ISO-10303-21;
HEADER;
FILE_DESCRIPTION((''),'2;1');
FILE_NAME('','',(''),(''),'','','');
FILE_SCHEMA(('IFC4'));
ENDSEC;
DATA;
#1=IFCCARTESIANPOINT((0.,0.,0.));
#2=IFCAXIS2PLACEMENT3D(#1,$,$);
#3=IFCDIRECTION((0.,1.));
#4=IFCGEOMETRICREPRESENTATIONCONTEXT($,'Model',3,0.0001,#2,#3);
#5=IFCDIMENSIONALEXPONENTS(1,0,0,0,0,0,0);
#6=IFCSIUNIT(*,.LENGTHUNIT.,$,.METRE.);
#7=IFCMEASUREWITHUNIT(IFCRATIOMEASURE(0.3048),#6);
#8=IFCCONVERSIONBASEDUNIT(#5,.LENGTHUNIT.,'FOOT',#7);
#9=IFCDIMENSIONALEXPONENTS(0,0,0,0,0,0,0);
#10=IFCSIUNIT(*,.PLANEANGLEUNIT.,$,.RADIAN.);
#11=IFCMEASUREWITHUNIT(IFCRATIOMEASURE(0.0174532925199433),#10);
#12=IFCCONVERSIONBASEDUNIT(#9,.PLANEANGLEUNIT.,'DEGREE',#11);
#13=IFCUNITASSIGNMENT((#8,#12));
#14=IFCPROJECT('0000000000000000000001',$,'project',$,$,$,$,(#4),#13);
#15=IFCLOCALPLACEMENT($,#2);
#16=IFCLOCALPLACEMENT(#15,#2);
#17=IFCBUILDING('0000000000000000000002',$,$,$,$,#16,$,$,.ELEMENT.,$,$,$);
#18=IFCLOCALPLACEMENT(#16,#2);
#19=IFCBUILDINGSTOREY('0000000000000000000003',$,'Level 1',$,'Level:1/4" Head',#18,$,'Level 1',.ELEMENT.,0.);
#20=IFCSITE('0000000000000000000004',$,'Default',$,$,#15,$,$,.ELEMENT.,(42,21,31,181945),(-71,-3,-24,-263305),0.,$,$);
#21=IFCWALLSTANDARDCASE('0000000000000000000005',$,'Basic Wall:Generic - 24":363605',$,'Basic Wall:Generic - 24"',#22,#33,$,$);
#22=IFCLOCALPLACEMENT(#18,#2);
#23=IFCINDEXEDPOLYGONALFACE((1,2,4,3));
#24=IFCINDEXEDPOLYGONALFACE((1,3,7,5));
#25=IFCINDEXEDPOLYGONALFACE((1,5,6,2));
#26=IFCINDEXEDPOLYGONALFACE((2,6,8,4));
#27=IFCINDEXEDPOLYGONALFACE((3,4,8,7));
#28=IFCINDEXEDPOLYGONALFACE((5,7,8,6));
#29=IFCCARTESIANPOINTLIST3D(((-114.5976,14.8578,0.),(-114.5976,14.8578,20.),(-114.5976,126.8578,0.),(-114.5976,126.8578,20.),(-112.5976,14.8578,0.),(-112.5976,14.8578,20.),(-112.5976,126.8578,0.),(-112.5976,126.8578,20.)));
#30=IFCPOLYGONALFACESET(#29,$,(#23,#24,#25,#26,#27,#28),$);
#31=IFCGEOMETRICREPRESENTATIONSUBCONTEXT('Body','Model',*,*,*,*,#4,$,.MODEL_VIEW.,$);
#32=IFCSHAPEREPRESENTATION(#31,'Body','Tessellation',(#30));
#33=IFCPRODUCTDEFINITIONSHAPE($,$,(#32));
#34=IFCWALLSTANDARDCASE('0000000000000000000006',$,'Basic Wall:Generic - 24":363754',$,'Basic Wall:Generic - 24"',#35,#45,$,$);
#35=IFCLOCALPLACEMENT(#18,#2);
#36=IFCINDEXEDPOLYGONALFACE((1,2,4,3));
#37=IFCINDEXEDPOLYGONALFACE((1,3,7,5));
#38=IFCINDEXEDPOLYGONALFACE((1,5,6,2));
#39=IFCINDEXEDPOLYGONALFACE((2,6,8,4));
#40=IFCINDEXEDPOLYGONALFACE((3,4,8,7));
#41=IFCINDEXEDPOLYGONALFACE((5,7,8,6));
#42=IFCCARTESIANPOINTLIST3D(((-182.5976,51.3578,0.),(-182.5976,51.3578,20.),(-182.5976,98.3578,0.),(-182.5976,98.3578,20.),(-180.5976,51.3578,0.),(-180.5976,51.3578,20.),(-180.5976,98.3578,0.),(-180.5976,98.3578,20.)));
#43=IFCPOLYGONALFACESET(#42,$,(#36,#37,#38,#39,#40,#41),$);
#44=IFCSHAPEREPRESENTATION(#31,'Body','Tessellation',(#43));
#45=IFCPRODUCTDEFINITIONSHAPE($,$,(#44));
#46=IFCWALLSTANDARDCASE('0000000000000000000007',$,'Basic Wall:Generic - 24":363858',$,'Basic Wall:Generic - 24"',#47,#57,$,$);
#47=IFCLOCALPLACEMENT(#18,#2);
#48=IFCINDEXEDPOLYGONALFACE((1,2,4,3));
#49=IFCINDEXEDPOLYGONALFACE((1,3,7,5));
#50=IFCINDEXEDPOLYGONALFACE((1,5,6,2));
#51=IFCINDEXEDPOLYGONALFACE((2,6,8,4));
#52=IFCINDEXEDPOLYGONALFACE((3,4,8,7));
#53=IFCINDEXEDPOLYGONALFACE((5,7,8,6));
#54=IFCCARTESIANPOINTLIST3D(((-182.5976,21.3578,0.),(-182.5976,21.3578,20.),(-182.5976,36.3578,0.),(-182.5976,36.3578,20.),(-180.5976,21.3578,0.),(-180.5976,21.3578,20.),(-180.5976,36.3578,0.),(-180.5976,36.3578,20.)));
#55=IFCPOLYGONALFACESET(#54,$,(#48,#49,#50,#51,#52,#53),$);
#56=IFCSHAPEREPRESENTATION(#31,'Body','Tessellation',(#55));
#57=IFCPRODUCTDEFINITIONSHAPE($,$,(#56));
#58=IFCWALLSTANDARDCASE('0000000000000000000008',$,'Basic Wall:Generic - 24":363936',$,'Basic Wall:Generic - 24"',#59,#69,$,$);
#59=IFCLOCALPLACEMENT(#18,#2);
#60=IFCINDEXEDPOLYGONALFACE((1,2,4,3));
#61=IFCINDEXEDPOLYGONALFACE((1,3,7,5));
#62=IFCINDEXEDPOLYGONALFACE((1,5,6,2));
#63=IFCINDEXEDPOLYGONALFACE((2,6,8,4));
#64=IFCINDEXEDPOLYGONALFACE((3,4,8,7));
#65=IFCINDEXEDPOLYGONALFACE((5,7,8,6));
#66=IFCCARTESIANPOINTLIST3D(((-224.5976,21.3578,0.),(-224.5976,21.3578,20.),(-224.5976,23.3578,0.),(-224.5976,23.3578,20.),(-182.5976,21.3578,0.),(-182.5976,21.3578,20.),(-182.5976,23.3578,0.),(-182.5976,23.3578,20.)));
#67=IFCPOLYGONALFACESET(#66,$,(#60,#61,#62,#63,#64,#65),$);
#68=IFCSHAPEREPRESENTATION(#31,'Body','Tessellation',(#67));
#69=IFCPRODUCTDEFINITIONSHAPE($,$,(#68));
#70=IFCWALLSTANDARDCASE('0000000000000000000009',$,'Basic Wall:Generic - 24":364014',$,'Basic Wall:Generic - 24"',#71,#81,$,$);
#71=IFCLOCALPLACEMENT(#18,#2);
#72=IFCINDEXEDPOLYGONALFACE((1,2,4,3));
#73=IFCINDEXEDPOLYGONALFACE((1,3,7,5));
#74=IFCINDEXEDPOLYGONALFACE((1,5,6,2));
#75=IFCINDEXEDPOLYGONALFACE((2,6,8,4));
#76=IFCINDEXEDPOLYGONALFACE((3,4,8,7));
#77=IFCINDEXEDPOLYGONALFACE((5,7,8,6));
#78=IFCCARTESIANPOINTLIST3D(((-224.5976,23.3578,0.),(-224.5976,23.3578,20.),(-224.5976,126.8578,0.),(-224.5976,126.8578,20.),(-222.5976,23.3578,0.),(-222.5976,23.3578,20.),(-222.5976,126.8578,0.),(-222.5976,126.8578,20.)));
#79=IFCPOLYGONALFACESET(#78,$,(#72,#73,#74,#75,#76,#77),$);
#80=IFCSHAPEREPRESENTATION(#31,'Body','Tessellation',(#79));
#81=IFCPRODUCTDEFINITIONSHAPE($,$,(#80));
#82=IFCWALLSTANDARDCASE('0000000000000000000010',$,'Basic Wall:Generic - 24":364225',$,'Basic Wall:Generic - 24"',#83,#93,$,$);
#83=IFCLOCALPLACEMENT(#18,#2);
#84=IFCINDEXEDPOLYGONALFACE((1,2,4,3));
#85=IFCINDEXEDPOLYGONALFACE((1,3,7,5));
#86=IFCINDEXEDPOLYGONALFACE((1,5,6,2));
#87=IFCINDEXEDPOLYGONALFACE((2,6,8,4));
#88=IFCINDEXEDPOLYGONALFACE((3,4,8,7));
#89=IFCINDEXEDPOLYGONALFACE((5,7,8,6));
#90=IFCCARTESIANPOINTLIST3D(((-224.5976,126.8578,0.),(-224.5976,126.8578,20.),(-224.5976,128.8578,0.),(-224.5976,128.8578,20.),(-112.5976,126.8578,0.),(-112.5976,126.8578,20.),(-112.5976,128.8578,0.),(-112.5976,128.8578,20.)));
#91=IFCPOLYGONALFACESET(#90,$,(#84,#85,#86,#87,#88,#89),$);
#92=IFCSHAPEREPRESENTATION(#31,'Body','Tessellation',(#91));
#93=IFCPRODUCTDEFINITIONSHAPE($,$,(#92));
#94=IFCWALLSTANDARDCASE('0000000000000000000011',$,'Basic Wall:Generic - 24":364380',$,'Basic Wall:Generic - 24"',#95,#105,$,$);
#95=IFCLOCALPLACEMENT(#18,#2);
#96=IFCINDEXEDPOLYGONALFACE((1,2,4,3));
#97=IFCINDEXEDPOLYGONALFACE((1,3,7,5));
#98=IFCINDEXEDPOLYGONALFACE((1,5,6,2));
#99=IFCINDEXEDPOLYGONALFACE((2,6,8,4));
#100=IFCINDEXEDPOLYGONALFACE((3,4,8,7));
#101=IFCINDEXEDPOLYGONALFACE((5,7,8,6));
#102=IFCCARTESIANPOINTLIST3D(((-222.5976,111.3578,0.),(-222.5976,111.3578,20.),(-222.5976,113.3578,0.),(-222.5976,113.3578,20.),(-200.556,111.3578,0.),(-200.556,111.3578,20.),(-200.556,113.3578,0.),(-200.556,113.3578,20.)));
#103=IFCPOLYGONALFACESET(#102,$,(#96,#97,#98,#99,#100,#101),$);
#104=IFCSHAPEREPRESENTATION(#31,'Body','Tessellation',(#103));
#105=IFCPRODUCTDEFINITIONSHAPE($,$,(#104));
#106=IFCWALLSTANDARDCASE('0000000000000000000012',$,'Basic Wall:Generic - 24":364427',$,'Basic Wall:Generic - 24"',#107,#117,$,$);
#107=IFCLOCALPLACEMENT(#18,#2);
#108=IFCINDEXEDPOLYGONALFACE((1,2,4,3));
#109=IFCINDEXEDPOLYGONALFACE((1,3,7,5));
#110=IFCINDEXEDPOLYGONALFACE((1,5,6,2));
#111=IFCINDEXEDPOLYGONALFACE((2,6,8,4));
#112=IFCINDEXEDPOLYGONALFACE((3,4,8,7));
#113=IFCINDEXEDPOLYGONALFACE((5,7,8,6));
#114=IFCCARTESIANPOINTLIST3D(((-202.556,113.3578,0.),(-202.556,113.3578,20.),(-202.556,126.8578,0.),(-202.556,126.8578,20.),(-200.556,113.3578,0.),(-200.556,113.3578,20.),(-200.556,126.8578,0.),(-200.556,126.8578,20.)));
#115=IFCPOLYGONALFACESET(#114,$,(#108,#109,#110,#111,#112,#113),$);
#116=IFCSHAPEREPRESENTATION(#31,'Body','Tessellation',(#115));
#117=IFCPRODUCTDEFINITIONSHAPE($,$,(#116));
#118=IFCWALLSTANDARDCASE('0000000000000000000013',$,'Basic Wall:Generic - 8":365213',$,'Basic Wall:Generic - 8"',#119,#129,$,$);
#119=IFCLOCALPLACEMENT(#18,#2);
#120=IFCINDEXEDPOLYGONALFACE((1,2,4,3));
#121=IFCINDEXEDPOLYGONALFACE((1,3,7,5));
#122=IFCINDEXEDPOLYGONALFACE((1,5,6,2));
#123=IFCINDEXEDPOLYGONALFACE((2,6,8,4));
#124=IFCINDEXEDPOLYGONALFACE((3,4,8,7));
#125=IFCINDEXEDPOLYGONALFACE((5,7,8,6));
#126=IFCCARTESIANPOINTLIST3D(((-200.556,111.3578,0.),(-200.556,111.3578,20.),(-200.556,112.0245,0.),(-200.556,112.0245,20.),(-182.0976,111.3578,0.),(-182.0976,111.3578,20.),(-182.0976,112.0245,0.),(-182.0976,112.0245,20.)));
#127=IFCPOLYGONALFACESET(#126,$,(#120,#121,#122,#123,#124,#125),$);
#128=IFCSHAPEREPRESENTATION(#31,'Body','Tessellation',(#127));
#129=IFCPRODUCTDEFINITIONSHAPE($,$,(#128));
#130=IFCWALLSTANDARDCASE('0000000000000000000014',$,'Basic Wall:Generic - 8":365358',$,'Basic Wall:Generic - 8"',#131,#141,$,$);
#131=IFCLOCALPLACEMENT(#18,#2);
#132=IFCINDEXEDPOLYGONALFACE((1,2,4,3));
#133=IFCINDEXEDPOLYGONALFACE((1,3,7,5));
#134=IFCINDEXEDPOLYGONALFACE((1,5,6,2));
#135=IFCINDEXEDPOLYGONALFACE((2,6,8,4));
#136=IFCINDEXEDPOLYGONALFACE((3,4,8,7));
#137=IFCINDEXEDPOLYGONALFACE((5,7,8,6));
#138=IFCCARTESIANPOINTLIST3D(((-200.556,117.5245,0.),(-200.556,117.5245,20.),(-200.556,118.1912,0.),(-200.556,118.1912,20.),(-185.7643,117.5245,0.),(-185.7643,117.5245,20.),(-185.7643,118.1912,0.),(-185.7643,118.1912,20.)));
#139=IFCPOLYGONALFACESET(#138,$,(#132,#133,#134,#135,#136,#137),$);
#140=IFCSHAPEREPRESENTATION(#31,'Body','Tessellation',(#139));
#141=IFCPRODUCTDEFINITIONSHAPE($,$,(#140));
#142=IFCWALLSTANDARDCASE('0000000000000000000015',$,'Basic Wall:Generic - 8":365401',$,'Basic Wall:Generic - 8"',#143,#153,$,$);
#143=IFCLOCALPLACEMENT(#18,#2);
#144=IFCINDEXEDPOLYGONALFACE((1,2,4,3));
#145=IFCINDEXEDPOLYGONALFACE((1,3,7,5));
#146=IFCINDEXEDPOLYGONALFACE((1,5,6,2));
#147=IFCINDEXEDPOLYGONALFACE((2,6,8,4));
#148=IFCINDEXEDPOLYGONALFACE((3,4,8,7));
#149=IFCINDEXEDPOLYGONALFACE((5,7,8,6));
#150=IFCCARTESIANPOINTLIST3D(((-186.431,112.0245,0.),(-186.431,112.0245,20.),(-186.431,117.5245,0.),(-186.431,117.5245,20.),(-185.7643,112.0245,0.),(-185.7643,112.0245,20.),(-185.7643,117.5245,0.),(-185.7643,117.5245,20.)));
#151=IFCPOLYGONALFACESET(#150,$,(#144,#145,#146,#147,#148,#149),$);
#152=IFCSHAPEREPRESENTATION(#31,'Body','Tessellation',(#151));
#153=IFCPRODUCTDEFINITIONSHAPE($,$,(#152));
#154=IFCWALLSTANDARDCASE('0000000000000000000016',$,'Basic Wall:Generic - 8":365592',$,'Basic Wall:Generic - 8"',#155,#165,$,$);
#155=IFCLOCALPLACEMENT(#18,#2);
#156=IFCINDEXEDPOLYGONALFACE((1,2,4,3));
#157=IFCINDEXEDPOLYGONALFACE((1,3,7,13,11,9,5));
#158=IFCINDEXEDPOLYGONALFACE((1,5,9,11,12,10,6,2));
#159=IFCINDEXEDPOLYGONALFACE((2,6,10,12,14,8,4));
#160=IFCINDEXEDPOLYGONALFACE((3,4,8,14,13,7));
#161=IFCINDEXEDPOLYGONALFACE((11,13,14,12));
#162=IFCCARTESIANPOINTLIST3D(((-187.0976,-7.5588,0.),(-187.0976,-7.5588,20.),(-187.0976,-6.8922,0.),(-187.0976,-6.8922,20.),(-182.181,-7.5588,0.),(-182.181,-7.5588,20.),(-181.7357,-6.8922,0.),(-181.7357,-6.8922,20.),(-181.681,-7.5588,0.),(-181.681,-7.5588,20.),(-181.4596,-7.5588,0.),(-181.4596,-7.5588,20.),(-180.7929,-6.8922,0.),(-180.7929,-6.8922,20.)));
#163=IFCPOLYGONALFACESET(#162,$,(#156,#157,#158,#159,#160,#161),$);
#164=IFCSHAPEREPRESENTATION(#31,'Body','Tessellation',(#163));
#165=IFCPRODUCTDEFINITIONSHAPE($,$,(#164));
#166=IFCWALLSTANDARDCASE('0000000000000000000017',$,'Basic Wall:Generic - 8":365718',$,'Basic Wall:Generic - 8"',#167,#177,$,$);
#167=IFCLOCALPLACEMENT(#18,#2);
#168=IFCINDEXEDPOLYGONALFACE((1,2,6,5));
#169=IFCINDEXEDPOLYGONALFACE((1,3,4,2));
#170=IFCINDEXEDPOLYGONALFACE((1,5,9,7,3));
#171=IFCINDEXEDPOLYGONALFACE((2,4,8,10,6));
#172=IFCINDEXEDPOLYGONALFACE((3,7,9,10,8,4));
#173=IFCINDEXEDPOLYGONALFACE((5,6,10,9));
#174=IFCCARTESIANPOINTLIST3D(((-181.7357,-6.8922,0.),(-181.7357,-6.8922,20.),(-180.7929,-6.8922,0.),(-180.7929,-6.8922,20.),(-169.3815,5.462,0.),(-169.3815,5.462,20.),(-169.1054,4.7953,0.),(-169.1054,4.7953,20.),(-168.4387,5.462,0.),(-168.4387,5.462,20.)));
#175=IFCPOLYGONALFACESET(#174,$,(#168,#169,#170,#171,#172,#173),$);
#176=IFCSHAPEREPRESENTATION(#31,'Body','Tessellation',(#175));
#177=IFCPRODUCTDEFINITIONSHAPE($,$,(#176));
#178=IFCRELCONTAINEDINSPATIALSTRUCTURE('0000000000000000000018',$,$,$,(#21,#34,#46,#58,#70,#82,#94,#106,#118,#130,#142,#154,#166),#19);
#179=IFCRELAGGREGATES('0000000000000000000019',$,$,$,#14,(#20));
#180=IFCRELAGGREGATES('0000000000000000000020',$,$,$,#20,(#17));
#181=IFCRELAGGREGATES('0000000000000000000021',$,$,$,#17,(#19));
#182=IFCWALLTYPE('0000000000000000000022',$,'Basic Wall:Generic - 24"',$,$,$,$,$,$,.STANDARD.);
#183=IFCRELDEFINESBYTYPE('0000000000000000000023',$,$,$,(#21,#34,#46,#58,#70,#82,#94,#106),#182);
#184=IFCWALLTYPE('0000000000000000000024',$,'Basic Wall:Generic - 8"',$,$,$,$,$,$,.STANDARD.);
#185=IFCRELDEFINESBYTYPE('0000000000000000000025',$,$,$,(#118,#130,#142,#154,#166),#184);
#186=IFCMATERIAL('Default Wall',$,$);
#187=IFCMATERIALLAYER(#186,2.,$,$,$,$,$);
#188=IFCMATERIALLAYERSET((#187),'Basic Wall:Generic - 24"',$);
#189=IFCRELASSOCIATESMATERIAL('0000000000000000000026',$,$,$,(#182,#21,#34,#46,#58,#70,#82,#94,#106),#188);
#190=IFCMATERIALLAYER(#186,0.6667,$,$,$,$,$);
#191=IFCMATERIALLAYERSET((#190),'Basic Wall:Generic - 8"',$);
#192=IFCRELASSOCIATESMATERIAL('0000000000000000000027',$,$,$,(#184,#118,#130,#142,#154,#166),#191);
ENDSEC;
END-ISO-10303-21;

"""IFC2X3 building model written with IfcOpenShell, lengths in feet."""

from ifc_helpers import new_model, entity, si_unit, converted_unit, direction, frame, frame_2d, origin, place, context, subcontext, project, spatial, polyline, rectangle, outline, extrude, material, layer, layer_set, layer_usage, type_object, element, save


model = new_model("IFC2X3")

# Units and contexts
model_context = context("Model", 3, precision=0.0001, world=origin(), true_north=direction((0.0, 1.0)))
body_context = subcontext(model_context, "Body", "Model", "MODEL_VIEW")
ifc_project = project(units=[converted_unit("LENGTHUNIT", "FOOT", entity("IfcRatioMeasure", 0.3048), si_unit("LENGTHUNIT", "METRE"), dimensions=[1, 0, 0, 0, 0, 0, 0]), converted_unit("PLANEANGLEUNIT", "DEGREE", entity("IfcRatioMeasure", 0.0174532925199433), si_unit("PLANEANGLEUNIT", "RADIAN"), dimensions=[0, 0, 0, 0, 0, 0, 0])], contexts=[model_context])

# Site, building, storey
site_placement = place(None, origin())
site = spatial("IfcSite", under=ifc_project, at=site_placement, Name="Default", CompositionType="ELEMENT", RefLatitude=(42, 21, 31, 181945), RefLongitude=(-71, -3, -24, -263305), RefElevation=0.0)
building_placement = place(site_placement, origin())
building = spatial("IfcBuilding", under=site, at=building_placement, CompositionType="ELEMENT")
storey_placement = place(building_placement, origin())
storey = spatial("IfcBuildingStorey", under=building, at=storey_placement, Name="Level 1", ObjectType="Level:1/4\" Head", LongName="Level 1", CompositionType="ELEMENT", Elevation=0.0)

# Walls
ifc_material = material(Name="Default Wall")
ifc_layer_1 = layer(ifc_material, 2.0)
ifc_layer_set_1 = layer_set([ifc_layer_1], Name="Basic Wall:Generic - 24\"")
ifc_layer_usage_1 = layer_usage(ifc_layer_set_1, "AXIS2", "NEGATIVE", 1.0)
wall_type_1 = type_object("IfcWallType", Name="Basic Wall:Generic - 24\"", PredefinedType="STANDARD", material=ifc_layer_set_1)
wall_1_placement = place(storey_placement, frame((-113.5976, 14.8578, 0.0), z_axis=(0.0, 0.0, 1.0), x_axis=(0.0, 1.0, 0.0)))
element("IfcWallStandardCase", 1, at=wall_1_placement, inside=storey, type_object=wall_type_1, material=ifc_layer_usage_1, Name="Basic Wall:Generic - 24\":363605", ObjectType="Basic Wall:Generic - 24\"", context=body_context, shape_type="SweptSolid", body=[
    extrude(rectangle(XDim=112.0, YDim=2.0, at=frame_2d((56.0, 0.0), x_axis=(-1.0, 0.0))), origin(), (0.0, 0.0, 1.0), 20.0),
])
ifc_layer_usage_2 = layer_usage(ifc_layer_set_1, "AXIS2", "NEGATIVE", 1.0)
wall_2_placement = place(storey_placement, frame((-181.5976, 98.3578, 0.0), z_axis=(0.0, 0.0, 1.0), x_axis=(0.0, -1.0, 0.0)))
element("IfcWallStandardCase", 2, at=wall_2_placement, inside=storey, type_object=wall_type_1, material=ifc_layer_usage_2, Name="Basic Wall:Generic - 24\":363754", ObjectType="Basic Wall:Generic - 24\"", context=body_context, shape_type="SweptSolid", body=[
    extrude(rectangle(XDim=47.0, YDim=2.0, at=frame_2d((23.5, 0.0), x_axis=(-1.0, 0.0))), origin(), (0.0, 0.0, 1.0), 20.0),
])
ifc_layer_usage_3 = layer_usage(ifc_layer_set_1, "AXIS2", "NEGATIVE", 1.0)
wall_3_placement = place(storey_placement, frame((-181.5976, 36.3578, 0.0), z_axis=(0.0, 0.0, 1.0), x_axis=(0.0, -1.0, 0.0)))
element("IfcWallStandardCase", 3, at=wall_3_placement, inside=storey, type_object=wall_type_1, material=ifc_layer_usage_3, Name="Basic Wall:Generic - 24\":363858", ObjectType="Basic Wall:Generic - 24\"", context=body_context, shape_type="SweptSolid", body=[
    extrude(rectangle(XDim=15.0, YDim=2.0, at=frame_2d((7.5, 0.0), x_axis=(-1.0, 0.0))), origin(), (0.0, 0.0, 1.0), 20.0),
])
ifc_layer_usage_4 = layer_usage(ifc_layer_set_1, "AXIS2", "NEGATIVE", 1.0)
wall_4_placement = place(storey_placement, frame((-182.5976, 22.3578, 0.0), z_axis=(0.0, 0.0, 1.0), x_axis=(-1.0, 0.0, 0.0)))
element("IfcWallStandardCase", 4, at=wall_4_placement, inside=storey, type_object=wall_type_1, material=ifc_layer_usage_4, Name="Basic Wall:Generic - 24\":363936", ObjectType="Basic Wall:Generic - 24\"", context=body_context, shape_type="SweptSolid", body=[
    extrude(rectangle(XDim=42.0, YDim=2.0, at=frame_2d((21.0, 0.0), x_axis=(-1.0, 0.0))), origin(), (0.0, 0.0, 1.0), 20.0),
])
ifc_layer_usage_5 = layer_usage(ifc_layer_set_1, "AXIS2", "NEGATIVE", 1.0)
wall_5_placement = place(storey_placement, frame((-223.5976, 23.3578, 0.0), z_axis=(0.0, 0.0, 1.0), x_axis=(0.0, 1.0, 0.0)))
element("IfcWallStandardCase", 5, at=wall_5_placement, inside=storey, type_object=wall_type_1, material=ifc_layer_usage_5, Name="Basic Wall:Generic - 24\":364014", ObjectType="Basic Wall:Generic - 24\"", context=body_context, shape_type="SweptSolid", body=[
    extrude(rectangle(XDim=103.5, YDim=2.0, at=frame_2d((51.75, 0.0), x_axis=(-1.0, 0.0))), origin(), (0.0, 0.0, 1.0), 20.0),
])
ifc_layer_usage_6 = layer_usage(ifc_layer_set_1, "AXIS2", "NEGATIVE", 1.0)
wall_6_placement = place(storey_placement, frame((-224.5976, 127.8578, 0.0)))
element("IfcWallStandardCase", 6, at=wall_6_placement, inside=storey, type_object=wall_type_1, material=ifc_layer_usage_6, Name="Basic Wall:Generic - 24\":364225", ObjectType="Basic Wall:Generic - 24\"", context=body_context, shape_type="SweptSolid", body=[
    extrude(rectangle(XDim=112.0, YDim=2.0, at=frame_2d((56.0, 0.0), x_axis=(-1.0, 0.0))), origin(), (0.0, 0.0, 1.0), 20.0),
])
ifc_layer_usage_7 = layer_usage(ifc_layer_set_1, "AXIS2", "NEGATIVE", 1.0)
wall_7_placement = place(storey_placement, frame((-222.5976, 112.3578, 0.0)))
element("IfcWallStandardCase", 7, at=wall_7_placement, inside=storey, type_object=wall_type_1, material=ifc_layer_usage_7, Name="Basic Wall:Generic - 24\":364380", ObjectType="Basic Wall:Generic - 24\"", context=body_context, shape_type="SweptSolid", body=[
    extrude(rectangle(XDim=22.0417, YDim=2.0, at=frame_2d((11.0208, 0.0), x_axis=(-1.0, 0.0))), origin(), (0.0, 0.0, 1.0), 20.0),
])
ifc_layer_usage_8 = layer_usage(ifc_layer_set_1, "AXIS2", "NEGATIVE", 1.0)
wall_8_placement = place(storey_placement, frame((-201.556, 113.3578, 0.0), z_axis=(0.0, 0.0, 1.0), x_axis=(0.0, 1.0, 0.0)))
element("IfcWallStandardCase", 8, at=wall_8_placement, inside=storey, type_object=wall_type_1, material=ifc_layer_usage_8, Name="Basic Wall:Generic - 24\":364427", ObjectType="Basic Wall:Generic - 24\"", context=body_context, shape_type="SweptSolid", body=[
    extrude(rectangle(XDim=13.5, YDim=2.0, at=frame_2d((6.75, 0.0), x_axis=(-1.0, 0.0))), origin(), (0.0, 0.0, 1.0), 20.0),
])
ifc_layer_2 = layer(ifc_material, 0.6667)
ifc_layer_set_2 = layer_set([ifc_layer_2], Name="Basic Wall:Generic - 8\"")
ifc_layer_usage_9 = layer_usage(ifc_layer_set_2, "AXIS2", "NEGATIVE", 0.3333)
wall_type_2 = type_object("IfcWallType", Name="Basic Wall:Generic - 8\"", PredefinedType="STANDARD", material=ifc_layer_set_2)
wall_9_placement = place(storey_placement, frame((-182.0976, 111.6912, 0.0), z_axis=(0.0, 0.0, 1.0), x_axis=(-1.0, 0.0, 0.0)))
element("IfcWallStandardCase", 9, at=wall_9_placement, inside=storey, type_object=wall_type_2, material=ifc_layer_usage_9, Name="Basic Wall:Generic - 8\":365213", ObjectType="Basic Wall:Generic - 8\"", context=body_context, shape_type="SweptSolid", body=[
    extrude(rectangle(XDim=18.4583, YDim=0.6667, at=frame_2d((9.2292, 0.0), x_axis=(-1.0, 0.0))), origin(), (0.0, 0.0, 1.0), 20.0),
])
ifc_layer_usage_10 = layer_usage(ifc_layer_set_2, "AXIS2", "NEGATIVE", 0.3333)
wall_10_placement = place(storey_placement, frame((-200.556, 117.8578, 0.0)))
element("IfcWallStandardCase", 10, at=wall_10_placement, inside=storey, type_object=wall_type_2, material=ifc_layer_usage_10, Name="Basic Wall:Generic - 8\":365358", ObjectType="Basic Wall:Generic - 8\"", context=body_context, shape_type="SweptSolid", body=[
    extrude(rectangle(XDim=14.7917, YDim=0.6667, at=frame_2d((7.3958, 0.0), x_axis=(-1.0, 0.0))), origin(), (0.0, 0.0, 1.0), 20.0),
])
ifc_layer_usage_11 = layer_usage(ifc_layer_set_2, "AXIS2", "NEGATIVE", 0.3333)
wall_11_placement = place(storey_placement, frame((-186.0976, 117.5245, 0.0), z_axis=(0.0, 0.0, 1.0), x_axis=(0.0, -1.0, 0.0)))
element("IfcWallStandardCase", 11, at=wall_11_placement, inside=storey, type_object=wall_type_2, material=ifc_layer_usage_11, Name="Basic Wall:Generic - 8\":365401", ObjectType="Basic Wall:Generic - 8\"", context=body_context, shape_type="SweptSolid", body=[
    extrude(rectangle(XDim=5.5, YDim=0.6667, at=frame_2d((2.75, 0.0), x_axis=(-1.0, 0.0))), origin(), (0.0, 0.0, 1.0), 20.0),
])
ifc_layer_usage_12 = layer_usage(ifc_layer_set_2, "AXIS2", "NEGATIVE", 0.3333)
wall_12_placement = place(storey_placement, frame((-187.0976, -7.2255, 0.0)))
element("IfcWallStandardCase", 12, at=wall_12_placement, inside=storey, type_object=wall_type_2, material=ifc_layer_usage_12, Name="Basic Wall:Generic - 8\":365592", ObjectType="Basic Wall:Generic - 8\"", context=body_context, shape_type="SweptSolid", body=[
    extrude(outline(polyline([(5.6381, -0.3333), (6.3047, 0.3333), (5.3619, 0.3333), (0.0, 0.3333), (0.0, -0.3333), (4.9167, -0.3333), (5.4167, -0.3333), (5.6381, -0.3333)])), origin(), (0.0, 0.0, 1.0), 20.0),
])
ifc_layer_usage_13 = layer_usage(ifc_layer_set_2, "AXIS2", "NEGATIVE", 0.3333)
wall_13_placement = place(storey_placement, frame((-181.5, -7.1279, 0.0), z_axis=(0.0, 0.0, 1.0), x_axis=(0.707107, 0.707107, 0.0)))
element("IfcWallStandardCase", 13, at=wall_13_placement, inside=storey, type_object=wall_type_2, material=ifc_layer_usage_13, Name="Basic Wall:Generic - 8\":365718", ObjectType="Basic Wall:Generic - 8\"", context=body_context, shape_type="SweptSolid", body=[
    extrude(outline(polyline([(18.1381, -0.3333), (17.4714, 0.3333), (0.0, 0.3333), (0.6667, -0.3333), (17.1953, -0.3333), (18.1381, -0.3333)])), origin(), (0.0, 0.0, 1.0), 20.0),
])

save(model, "model.ifc")
